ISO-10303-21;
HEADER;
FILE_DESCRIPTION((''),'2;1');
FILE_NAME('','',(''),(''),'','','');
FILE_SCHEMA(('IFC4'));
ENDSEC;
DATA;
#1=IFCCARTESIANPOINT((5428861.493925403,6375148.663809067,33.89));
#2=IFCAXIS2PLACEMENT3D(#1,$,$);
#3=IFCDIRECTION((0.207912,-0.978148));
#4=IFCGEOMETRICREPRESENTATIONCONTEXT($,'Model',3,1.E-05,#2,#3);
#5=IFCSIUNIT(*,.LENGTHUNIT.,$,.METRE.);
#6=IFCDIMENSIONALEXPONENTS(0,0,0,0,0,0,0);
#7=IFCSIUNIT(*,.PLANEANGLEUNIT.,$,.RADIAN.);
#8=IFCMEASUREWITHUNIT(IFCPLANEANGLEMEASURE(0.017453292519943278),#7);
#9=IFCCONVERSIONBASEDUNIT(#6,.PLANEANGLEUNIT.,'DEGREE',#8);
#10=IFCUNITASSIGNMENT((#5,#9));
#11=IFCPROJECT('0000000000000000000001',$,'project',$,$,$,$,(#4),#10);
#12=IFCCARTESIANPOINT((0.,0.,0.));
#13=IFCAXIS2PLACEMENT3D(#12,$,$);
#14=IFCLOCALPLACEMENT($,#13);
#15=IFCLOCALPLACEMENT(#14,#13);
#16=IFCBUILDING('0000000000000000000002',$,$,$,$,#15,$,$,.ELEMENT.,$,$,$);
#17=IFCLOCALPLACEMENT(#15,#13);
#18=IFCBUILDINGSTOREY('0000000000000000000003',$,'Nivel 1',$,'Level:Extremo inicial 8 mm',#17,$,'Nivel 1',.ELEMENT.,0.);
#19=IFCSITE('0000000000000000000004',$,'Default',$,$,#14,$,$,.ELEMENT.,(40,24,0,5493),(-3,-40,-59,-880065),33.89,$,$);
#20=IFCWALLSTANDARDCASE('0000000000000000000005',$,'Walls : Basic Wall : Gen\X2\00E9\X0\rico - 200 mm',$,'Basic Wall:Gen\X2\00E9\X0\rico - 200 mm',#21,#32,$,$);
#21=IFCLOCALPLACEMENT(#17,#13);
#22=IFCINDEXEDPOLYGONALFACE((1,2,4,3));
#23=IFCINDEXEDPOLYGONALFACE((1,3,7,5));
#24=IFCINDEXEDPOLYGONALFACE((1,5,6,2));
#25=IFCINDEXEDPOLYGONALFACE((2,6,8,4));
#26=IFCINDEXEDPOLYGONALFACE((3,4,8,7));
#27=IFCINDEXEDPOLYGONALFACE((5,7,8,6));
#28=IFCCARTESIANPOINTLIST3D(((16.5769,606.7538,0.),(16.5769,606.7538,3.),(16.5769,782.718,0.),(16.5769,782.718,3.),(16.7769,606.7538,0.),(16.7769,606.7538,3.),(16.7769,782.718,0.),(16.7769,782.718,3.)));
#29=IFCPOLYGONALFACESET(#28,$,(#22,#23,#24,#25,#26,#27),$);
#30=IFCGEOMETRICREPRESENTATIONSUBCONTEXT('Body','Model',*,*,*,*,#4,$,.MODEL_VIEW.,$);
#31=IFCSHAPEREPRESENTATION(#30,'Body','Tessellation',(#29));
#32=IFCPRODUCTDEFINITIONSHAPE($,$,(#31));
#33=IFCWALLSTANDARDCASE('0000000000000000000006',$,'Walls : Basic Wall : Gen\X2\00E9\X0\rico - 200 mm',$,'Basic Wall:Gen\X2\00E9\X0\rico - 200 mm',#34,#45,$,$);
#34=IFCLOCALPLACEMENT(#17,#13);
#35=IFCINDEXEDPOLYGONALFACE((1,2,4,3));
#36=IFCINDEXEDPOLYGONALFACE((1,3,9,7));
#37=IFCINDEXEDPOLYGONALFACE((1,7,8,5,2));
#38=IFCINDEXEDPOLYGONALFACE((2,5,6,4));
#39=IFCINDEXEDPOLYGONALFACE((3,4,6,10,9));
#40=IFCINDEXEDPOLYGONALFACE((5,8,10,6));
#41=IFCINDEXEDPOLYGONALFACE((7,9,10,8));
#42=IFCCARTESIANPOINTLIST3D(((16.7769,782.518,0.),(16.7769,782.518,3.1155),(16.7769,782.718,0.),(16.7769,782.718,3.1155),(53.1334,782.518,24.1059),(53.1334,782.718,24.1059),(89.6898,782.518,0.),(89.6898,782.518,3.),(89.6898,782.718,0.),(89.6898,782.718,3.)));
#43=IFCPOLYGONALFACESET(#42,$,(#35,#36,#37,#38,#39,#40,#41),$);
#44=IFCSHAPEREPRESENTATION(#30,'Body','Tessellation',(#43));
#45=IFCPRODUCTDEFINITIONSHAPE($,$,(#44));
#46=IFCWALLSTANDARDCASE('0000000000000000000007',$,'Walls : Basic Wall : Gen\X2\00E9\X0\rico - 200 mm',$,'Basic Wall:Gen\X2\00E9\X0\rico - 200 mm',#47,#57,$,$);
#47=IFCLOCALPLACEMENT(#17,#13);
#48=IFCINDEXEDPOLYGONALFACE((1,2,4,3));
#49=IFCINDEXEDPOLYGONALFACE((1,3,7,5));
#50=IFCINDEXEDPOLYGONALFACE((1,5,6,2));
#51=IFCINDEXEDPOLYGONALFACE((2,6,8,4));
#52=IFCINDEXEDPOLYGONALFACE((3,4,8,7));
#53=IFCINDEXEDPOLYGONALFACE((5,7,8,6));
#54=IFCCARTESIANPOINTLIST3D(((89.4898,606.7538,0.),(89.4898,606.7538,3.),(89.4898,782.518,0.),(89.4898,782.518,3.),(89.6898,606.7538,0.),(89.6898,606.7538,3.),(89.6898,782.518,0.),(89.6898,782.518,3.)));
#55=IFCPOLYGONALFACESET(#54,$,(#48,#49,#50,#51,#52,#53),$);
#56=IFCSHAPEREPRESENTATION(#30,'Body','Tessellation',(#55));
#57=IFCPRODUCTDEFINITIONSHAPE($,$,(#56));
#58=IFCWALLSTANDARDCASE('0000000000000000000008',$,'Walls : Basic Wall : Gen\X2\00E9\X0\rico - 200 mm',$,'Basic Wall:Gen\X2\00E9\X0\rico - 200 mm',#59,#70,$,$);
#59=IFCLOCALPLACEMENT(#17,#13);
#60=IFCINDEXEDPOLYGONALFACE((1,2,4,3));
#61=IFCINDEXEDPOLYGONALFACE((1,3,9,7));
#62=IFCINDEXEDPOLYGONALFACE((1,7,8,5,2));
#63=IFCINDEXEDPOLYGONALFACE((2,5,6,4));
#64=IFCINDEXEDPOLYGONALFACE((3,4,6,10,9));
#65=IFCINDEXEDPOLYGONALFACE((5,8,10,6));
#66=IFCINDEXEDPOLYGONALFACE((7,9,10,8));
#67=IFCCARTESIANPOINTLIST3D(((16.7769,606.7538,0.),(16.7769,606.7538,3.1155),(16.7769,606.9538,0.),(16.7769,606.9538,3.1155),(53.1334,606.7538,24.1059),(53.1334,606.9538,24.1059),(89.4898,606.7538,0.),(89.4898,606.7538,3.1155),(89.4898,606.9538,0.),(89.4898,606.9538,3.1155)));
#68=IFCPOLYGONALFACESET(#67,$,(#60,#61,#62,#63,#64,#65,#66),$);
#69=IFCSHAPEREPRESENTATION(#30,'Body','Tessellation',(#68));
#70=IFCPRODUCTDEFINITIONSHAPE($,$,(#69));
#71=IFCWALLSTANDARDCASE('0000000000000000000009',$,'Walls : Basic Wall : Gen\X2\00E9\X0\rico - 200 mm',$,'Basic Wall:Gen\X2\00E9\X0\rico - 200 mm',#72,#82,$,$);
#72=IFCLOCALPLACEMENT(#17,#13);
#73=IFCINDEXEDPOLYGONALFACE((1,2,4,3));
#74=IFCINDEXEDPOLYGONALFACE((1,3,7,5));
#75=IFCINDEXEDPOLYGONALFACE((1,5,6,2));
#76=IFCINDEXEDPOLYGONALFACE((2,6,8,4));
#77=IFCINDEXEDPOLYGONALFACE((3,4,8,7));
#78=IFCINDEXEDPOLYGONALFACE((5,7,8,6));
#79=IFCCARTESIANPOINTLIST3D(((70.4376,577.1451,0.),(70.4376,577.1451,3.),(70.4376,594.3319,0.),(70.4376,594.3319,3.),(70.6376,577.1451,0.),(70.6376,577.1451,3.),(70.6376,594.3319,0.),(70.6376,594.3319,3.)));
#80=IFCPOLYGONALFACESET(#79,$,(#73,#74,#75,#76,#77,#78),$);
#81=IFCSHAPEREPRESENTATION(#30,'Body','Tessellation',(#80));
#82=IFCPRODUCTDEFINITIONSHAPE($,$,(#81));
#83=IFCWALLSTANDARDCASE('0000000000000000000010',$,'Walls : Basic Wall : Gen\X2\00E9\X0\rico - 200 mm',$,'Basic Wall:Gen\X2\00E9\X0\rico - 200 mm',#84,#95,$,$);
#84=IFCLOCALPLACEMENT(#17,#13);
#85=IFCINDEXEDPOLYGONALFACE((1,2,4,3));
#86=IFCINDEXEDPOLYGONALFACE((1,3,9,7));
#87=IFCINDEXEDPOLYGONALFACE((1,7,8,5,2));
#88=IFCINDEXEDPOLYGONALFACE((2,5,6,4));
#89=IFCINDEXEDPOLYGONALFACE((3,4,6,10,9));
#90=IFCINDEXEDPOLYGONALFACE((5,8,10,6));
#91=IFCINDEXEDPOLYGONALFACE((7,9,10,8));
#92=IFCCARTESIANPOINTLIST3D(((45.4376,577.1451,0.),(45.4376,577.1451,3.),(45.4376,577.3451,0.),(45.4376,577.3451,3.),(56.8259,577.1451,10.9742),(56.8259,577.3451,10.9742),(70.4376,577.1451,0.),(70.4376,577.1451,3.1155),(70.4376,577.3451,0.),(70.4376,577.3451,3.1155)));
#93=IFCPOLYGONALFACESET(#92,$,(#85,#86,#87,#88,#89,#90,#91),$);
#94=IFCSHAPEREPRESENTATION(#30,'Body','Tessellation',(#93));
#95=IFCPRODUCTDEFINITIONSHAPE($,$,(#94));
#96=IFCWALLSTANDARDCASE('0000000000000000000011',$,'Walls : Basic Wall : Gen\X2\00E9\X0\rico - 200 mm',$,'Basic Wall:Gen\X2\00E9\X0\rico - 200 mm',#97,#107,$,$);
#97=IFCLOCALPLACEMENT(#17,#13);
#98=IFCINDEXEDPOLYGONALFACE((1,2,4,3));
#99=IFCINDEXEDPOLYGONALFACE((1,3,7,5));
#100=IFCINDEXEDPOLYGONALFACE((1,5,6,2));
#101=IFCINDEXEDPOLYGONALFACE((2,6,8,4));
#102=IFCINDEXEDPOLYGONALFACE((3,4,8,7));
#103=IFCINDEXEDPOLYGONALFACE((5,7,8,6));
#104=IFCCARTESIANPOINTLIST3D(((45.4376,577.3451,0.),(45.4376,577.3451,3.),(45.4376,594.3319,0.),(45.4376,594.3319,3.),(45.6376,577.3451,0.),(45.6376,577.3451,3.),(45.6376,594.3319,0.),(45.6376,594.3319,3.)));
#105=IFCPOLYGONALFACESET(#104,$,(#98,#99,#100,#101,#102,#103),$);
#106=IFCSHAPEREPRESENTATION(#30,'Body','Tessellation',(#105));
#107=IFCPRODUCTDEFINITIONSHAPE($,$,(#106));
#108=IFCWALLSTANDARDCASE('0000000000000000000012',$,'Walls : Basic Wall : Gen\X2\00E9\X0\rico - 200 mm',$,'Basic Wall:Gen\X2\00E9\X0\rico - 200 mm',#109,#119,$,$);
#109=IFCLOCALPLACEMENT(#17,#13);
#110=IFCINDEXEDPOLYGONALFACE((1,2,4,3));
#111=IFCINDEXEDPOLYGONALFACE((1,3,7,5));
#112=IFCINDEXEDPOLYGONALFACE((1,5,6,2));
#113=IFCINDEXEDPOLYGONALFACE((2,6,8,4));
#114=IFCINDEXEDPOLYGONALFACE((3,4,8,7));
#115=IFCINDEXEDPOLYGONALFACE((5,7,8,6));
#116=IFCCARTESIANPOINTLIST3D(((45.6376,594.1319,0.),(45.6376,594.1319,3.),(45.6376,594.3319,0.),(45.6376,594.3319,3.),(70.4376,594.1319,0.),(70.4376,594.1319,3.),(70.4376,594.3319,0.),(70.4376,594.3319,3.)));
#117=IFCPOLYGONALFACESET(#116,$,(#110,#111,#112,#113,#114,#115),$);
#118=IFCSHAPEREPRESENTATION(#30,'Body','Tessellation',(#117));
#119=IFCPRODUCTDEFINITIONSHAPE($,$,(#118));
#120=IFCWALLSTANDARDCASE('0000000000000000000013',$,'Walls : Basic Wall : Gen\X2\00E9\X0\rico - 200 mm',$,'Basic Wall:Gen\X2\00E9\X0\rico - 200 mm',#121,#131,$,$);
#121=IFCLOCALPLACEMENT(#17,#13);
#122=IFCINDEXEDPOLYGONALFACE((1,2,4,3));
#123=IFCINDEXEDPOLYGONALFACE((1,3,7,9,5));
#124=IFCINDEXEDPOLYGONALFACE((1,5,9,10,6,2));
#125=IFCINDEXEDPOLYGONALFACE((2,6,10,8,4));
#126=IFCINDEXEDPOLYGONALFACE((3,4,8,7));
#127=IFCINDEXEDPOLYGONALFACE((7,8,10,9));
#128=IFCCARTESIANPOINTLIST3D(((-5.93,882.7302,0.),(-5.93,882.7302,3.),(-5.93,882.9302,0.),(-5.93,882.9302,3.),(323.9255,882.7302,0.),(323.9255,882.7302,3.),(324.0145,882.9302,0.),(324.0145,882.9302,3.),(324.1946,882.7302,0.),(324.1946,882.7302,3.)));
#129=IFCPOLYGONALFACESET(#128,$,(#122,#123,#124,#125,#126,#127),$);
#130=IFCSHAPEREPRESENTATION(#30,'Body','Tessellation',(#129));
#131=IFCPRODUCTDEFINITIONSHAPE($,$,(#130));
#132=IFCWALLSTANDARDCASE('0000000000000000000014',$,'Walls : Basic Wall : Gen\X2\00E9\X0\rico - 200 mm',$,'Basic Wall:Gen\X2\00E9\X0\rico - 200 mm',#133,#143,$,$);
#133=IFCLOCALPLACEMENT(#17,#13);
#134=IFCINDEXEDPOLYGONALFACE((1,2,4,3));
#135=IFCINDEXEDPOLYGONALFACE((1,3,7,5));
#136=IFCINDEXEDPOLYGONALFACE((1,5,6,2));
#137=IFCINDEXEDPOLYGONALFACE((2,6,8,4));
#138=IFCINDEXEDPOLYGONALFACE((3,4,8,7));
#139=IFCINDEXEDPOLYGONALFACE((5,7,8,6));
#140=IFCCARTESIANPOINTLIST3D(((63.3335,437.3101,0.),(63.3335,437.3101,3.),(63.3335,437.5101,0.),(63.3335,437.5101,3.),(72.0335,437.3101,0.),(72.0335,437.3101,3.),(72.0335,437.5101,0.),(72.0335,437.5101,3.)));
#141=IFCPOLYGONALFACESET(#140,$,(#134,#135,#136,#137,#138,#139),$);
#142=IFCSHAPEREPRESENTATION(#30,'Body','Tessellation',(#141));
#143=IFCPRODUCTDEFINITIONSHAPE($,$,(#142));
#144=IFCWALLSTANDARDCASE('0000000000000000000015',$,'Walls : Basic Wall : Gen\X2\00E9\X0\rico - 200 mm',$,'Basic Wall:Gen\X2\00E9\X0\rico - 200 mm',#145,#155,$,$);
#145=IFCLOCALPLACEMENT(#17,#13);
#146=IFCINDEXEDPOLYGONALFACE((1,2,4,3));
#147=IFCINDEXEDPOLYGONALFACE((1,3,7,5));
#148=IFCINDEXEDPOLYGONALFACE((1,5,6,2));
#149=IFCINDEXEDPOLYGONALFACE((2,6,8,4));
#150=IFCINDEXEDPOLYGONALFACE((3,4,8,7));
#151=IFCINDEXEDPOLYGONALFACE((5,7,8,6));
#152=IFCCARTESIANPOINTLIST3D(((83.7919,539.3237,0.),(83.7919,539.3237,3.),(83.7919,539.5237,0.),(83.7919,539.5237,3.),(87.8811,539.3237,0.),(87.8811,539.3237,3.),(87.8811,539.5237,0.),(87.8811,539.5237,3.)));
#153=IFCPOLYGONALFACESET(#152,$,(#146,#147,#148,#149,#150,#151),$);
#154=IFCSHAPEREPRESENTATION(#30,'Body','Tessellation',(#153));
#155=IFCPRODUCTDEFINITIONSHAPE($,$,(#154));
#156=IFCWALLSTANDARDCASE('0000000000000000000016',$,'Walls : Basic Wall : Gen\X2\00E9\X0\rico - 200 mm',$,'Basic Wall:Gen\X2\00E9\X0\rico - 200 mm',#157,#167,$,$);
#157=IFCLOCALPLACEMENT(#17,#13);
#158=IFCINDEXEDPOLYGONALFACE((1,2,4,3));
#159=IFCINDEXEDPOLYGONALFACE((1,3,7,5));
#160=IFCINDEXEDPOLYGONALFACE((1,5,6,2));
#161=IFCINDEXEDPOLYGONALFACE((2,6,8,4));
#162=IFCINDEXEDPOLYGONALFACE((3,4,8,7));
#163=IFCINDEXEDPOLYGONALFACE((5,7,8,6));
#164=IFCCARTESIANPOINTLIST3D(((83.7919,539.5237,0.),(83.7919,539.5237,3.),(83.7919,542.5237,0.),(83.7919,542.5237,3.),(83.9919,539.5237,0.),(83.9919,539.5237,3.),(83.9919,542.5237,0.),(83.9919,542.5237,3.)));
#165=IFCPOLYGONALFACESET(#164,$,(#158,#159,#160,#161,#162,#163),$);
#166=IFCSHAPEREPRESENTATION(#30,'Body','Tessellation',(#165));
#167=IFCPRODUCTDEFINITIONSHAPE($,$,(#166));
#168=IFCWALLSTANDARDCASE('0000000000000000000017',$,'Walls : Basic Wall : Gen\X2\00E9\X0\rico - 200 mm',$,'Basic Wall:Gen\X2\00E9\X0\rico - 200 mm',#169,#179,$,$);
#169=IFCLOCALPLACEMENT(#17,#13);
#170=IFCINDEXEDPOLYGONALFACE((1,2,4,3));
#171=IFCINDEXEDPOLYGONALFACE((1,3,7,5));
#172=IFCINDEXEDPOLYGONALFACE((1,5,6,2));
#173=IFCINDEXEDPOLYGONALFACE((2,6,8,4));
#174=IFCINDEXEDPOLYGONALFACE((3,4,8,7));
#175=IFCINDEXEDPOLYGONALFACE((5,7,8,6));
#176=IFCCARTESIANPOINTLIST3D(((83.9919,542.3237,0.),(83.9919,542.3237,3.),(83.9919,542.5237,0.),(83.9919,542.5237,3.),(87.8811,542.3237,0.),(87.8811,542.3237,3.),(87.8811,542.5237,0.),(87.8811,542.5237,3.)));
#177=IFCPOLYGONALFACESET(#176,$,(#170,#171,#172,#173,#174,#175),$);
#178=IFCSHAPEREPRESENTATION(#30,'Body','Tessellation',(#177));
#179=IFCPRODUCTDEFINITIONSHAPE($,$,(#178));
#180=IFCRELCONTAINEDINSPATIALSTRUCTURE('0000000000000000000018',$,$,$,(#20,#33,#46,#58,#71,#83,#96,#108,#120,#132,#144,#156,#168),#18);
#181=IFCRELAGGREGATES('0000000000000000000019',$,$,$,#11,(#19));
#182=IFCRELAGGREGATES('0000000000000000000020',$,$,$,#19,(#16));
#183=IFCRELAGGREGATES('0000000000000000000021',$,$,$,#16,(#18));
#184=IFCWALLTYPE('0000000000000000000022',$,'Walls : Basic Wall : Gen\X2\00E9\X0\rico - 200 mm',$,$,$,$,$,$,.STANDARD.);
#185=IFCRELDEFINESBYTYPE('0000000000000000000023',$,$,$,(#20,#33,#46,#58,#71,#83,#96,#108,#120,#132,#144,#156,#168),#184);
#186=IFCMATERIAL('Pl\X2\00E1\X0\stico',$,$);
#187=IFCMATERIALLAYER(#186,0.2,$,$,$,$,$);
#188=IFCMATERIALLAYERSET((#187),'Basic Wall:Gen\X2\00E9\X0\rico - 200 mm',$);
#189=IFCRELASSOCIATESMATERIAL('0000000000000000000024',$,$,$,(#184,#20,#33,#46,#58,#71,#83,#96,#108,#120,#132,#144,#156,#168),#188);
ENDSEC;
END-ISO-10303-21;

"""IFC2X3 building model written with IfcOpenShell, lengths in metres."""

from ifc_helpers import new_model, entity, si_unit, converted_unit, direction, frame, frame_2d, origin, place, context, subcontext, project, spatial, polyline, rectangle, outline, extrude, clip, bounded_halfspace, material, layer, layer_set, layer_usage, type_object, element, save


model = new_model("IFC2X3")

# Units and contexts
model_context = context("Model", 3, precision=1e-05, world=frame((5428861.493925403, 6375148.663809067, 33.89)), true_north=direction((0.207912, -0.978148)))
body_context = subcontext(model_context, "Body", "Model", "MODEL_VIEW")
ifc_project = project(units=[si_unit("LENGTHUNIT", "METRE"), converted_unit("PLANEANGLEUNIT", "DEGREE", entity("IfcPlaneAngleMeasure", 0.017453292519943278), si_unit("PLANEANGLEUNIT", "RADIAN"), dimensions=[0, 0, 0, 0, 0, 0, 0])], contexts=[model_context])

# Site, building, storey
site_placement = place(None, origin())
site = spatial("IfcSite", under=ifc_project, at=site_placement, Name="Default", CompositionType="ELEMENT", RefLatitude=(40, 24, 0, 5493), RefLongitude=(-3, -40, -59, -880065), RefElevation=33.89)
building_placement = place(site_placement, origin())
building = spatial("IfcBuilding", under=site, at=building_placement, CompositionType="ELEMENT")
storey_placement = place(building_placement, origin())
storey = spatial("IfcBuildingStorey", under=building, at=storey_placement, Name="Nivel 1", ObjectType="Level:Extremo inicial 8 mm", LongName="Nivel 1", CompositionType="ELEMENT", Elevation=0.0)

# Walls
ifc_material_1 = material(Name="Plástico")
ifc_layer_1 = layer(ifc_material_1, 0.2)
ifc_layer_set_1 = layer_set([ifc_layer_1], Name="Basic Wall:Genérico - 200 mm")
ifc_layer_usage_1 = layer_usage(ifc_layer_set_1, "AXIS2", "NEGATIVE", 0.1)
wall_type = type_object("IfcWallType", Name="Walls : Basic Wall : Genérico - 200 mm", PredefinedType="STANDARD", material=ifc_layer_set_1)
wall_1_placement = place(storey_placement, frame((16.6769, 606.7538, 0.0), z_axis=(0.0, 0.0, 1.0), x_axis=(0.0, 1.0, 0.0)))
element("IfcWallStandardCase", 1, at=wall_1_placement, inside=storey, type_object=wall_type, material=ifc_layer_usage_1, Name="Walls : Basic Wall : Genérico - 200 mm", ObjectType="Basic Wall:Genérico - 200 mm", context=body_context, shape_type="SweptSolid", body=[
    extrude(rectangle(XDim=175.9642, YDim=0.2, at=frame_2d((87.9821, 0.0), x_axis=(-1.0, 0.0))), origin(), (0.0, 0.0, 1.0), 3.0),
])
ifc_layer_usage_2 = layer_usage(ifc_layer_set_1, "AXIS2", "NEGATIVE", 0.1)
wall_2_placement = place(storey_placement, frame((16.7769, 782.618, 0.0)))
element("IfcWallStandardCase", 2, at=wall_2_placement, inside=storey, type_object=wall_type, material=ifc_layer_usage_2, Name="Walls : Basic Wall : Genérico - 200 mm", ObjectType="Basic Wall:Genérico - 200 mm", context=body_context, shape_type="Clipping", body=[
    clip(clip(extrude(rectangle(XDim=72.9129, YDim=0.2, at=frame_2d((36.4564, 0.0), x_axis=(-1.0, 0.0))), origin(), (0.0, 0.0, 1.0), 24.1059), bounded_halfspace(frame((36.3564, -0.1, 24.1059), z_axis=(0.5, 0.0, 0.866025), x_axis=(0.0, 1.0, 0.0)), False, frame((36.3564, -0.1, 24.1059)), polyline([(0.0, 0.0), (36.5564, 0.0), (36.5564, 0.2), (0.0, 0.2), (0.0, 0.0)]))), bounded_halfspace(frame((0.0, -0.1, 3.1155), z_axis=(-0.5, 0.0, 0.866025), x_axis=(0.0, -1.0, 0.0)), False, frame((0.0, -0.1, 3.1155)), polyline([(0.0, 0.0), (36.3564, 0.0), (36.3564, 0.2), (0.0, 0.2), (0.0, 0.0)]))),
])
ifc_layer_usage_3 = layer_usage(ifc_layer_set_1, "AXIS2", "NEGATIVE", 0.1)
wall_3_placement = place(storey_placement, frame((89.5898, 782.518, 0.0), z_axis=(0.0, 0.0, 1.0), x_axis=(0.0, -1.0, 0.0)))
element("IfcWallStandardCase", 3, at=wall_3_placement, inside=storey, type_object=wall_type, material=ifc_layer_usage_3, Name="Walls : Basic Wall : Genérico - 200 mm", ObjectType="Basic Wall:Genérico - 200 mm", context=body_context, shape_type="SweptSolid", body=[
    extrude(rectangle(XDim=175.7642, YDim=0.2, at=frame_2d((87.8821, 0.0), x_axis=(-1.0, 0.0))), origin(), (0.0, 0.0, 1.0), 3.0),
])
ifc_layer_usage_4 = layer_usage(ifc_layer_set_1, "AXIS2", "NEGATIVE", 0.1)
wall_4_placement = place(storey_placement, frame((89.4898, 606.8538, 0.0), z_axis=(0.0, 0.0, 1.0), x_axis=(-1.0, 0.0, 0.0)))
element("IfcWallStandardCase", 4, at=wall_4_placement, inside=storey, type_object=wall_type, material=ifc_layer_usage_4, Name="Walls : Basic Wall : Genérico - 200 mm", ObjectType="Basic Wall:Genérico - 200 mm", context=body_context, shape_type="Clipping", body=[
    clip(clip(extrude(rectangle(XDim=72.7129, YDim=0.2, at=frame_2d((36.3564, 0.0), x_axis=(-1.0, 0.0))), origin(), (0.0, 0.0, 1.0), 24.1059), bounded_halfspace(frame((0.0, -0.1, 3.1155), z_axis=(-0.5, 0.0, 0.866025), x_axis=(0.0, -1.0, 0.0)), False, frame((0.0, -0.1, 3.1155)), polyline([(0.0, 0.0), (36.3564, 0.0), (36.3564, 0.2), (0.0, 0.2), (0.0, 0.0)]))), bounded_halfspace(frame((36.3564, -0.1, 24.1059), z_axis=(0.5, 0.0, 0.866025), x_axis=(0.0, 1.0, 0.0)), False, frame((36.3564, -0.1, 24.1059)), polyline([(0.0, 0.0), (36.3564, 0.0), (36.3564, 0.2), (0.0, 0.2), (0.0, 0.0)]))),
])
ifc_layer_usage_5 = layer_usage(ifc_layer_set_1, "AXIS2", "NEGATIVE", 0.1)
wall_5_placement = place(storey_placement, frame((70.5376, 594.3319, 0.0), z_axis=(0.0, 0.0, 1.0), x_axis=(0.0, -1.0, 0.0)))
element("IfcWallStandardCase", 5, at=wall_5_placement, inside=storey, type_object=wall_type, material=ifc_layer_usage_5, Name="Walls : Basic Wall : Genérico - 200 mm", ObjectType="Basic Wall:Genérico - 200 mm", context=body_context, shape_type="SweptSolid", body=[
    extrude(rectangle(XDim=17.1868, YDim=0.2, at=frame_2d((8.5934, 0.0), x_axis=(-1.0, 0.0))), origin(), (0.0, 0.0, 1.0), 3.0),
])
ifc_layer_usage_6 = layer_usage(ifc_layer_set_1, "AXIS2", "NEGATIVE", 0.1)
wall_6_placement = place(storey_placement, frame((70.4376, 577.2451, 0.0), z_axis=(0.0, 0.0, 1.0), x_axis=(-1.0, 0.0, 0.0)))
element("IfcWallStandardCase", 6, at=wall_6_placement, inside=storey, type_object=wall_type, material=ifc_layer_usage_6, Name="Walls : Basic Wall : Genérico - 200 mm", ObjectType="Basic Wall:Genérico - 200 mm", context=body_context, shape_type="Clipping", body=[
    clip(clip(extrude(rectangle(XDim=25.0, YDim=0.2, at=frame_2d((12.5, 0.0), x_axis=(-1.0, 0.0))), origin(), (0.0, 0.0, 1.0), 10.9742), bounded_halfspace(frame((0.0, -0.1, 3.1155), z_axis=(-0.5, 0.0, 0.866025), x_axis=(0.0, -1.0, 0.0)), False, frame((0.0, -0.1, 3.1155)), polyline([(0.0, 0.0), (13.6117, 0.0), (13.6117, 0.2), (0.0, 0.2), (0.0, 0.0)]))), bounded_halfspace(frame((13.6117, -0.1, 10.9742), z_axis=(0.573576, 0.0, 0.819152), x_axis=(0.0, 1.0, 0.0)), False, frame((13.6117, -0.1, 10.9742)), polyline([(0.0, 0.0), (11.3883, 0.0), (11.3883, 0.2), (0.0, 0.2), (0.0, 0.0)]))),
])
ifc_layer_usage_7 = layer_usage(ifc_layer_set_1, "AXIS2", "NEGATIVE", 0.1)
wall_7_placement = place(storey_placement, frame((45.5376, 577.3451, 0.0), z_axis=(0.0, 0.0, 1.0), x_axis=(0.0, 1.0, 0.0)))
element("IfcWallStandardCase", 7, at=wall_7_placement, inside=storey, type_object=wall_type, material=ifc_layer_usage_7, Name="Walls : Basic Wall : Genérico - 200 mm", ObjectType="Basic Wall:Genérico - 200 mm", context=body_context, shape_type="SweptSolid", body=[
    extrude(rectangle(XDim=16.9868, YDim=0.2, at=frame_2d((8.4934, 0.0), x_axis=(-1.0, 0.0))), origin(), (0.0, 0.0, 1.0), 3.0),
])
ifc_layer_usage_8 = layer_usage(ifc_layer_set_1, "AXIS2", "NEGATIVE", 0.1)
wall_8_placement = place(storey_placement, frame((70.4376, 594.2319, 0.0), z_axis=(0.0, 0.0, 1.0), x_axis=(-1.0, 0.0, 0.0)))
element("IfcWallStandardCase", 8, at=wall_8_placement, inside=storey, type_object=wall_type, material=ifc_layer_usage_8, Name="Walls : Basic Wall : Genérico - 200 mm", ObjectType="Basic Wall:Genérico - 200 mm", context=body_context, shape_type="SweptSolid", body=[
    extrude(rectangle(XDim=24.8, YDim=0.2, at=frame_2d((12.4, 0.0), x_axis=(-1.0, 0.0))), origin(), (0.0, 0.0, 1.0), 3.0),
])
ifc_layer_usage_9 = layer_usage(ifc_layer_set_1, "AXIS2", "NEGATIVE", 0.1)
wall_9_placement = place(storey_placement, frame((-5.93, 882.8302, 0.0)))
element("IfcWallStandardCase", 9, at=wall_9_placement, inside=storey, type_object=wall_type, material=ifc_layer_usage_9, Name="Walls : Basic Wall : Genérico - 200 mm", ObjectType="Basic Wall:Genérico - 200 mm", context=body_context, shape_type="SweptSolid", body=[
    extrude(outline(polyline([(330.1246, -0.1), (329.9445, 0.1), (0.0, 0.1), (0.0, -0.1), (329.8555, -0.1), (330.1246, -0.1)])), origin(), (0.0, 0.0, 1.0), 3.0),
])
ifc_layer_usage_10 = layer_usage(ifc_layer_set_1, "AXIS2", "NEGATIVE", 0.1)
wall_10_placement = place(storey_placement, frame((63.3335, 437.4101, 0.0)))
element("IfcWallStandardCase", 10, at=wall_10_placement, inside=storey, type_object=wall_type, material=ifc_layer_usage_10, Name="Walls : Basic Wall : Genérico - 200 mm", ObjectType="Basic Wall:Genérico - 200 mm", context=body_context, shape_type="SweptSolid", body=[
    extrude(rectangle(XDim=8.7, YDim=0.2, at=frame_2d((4.35, 0.0), x_axis=(-1.0, 0.0))), origin(), (0.0, 0.0, 1.0), 3.0),
])
ifc_layer_usage_11 = layer_usage(ifc_layer_set_1, "AXIS2", "NEGATIVE", 0.1)
wall_11_placement = place(storey_placement, frame((87.8811, 539.4237, 0.0), z_axis=(0.0, 0.0, 1.0), x_axis=(-1.0, 0.0, 0.0)))
element("IfcWallStandardCase", 11, at=wall_11_placement, inside=storey, type_object=wall_type, material=ifc_layer_usage_11, Name="Walls : Basic Wall : Genérico - 200 mm", ObjectType="Basic Wall:Genérico - 200 mm", context=body_context, shape_type="SweptSolid", body=[
    extrude(rectangle(XDim=4.0892, YDim=0.2, at=frame_2d((2.0446, 0.0), x_axis=(-1.0, 0.0))), origin(), (0.0, 0.0, 1.0), 3.0),
])
ifc_layer_usage_12 = layer_usage(ifc_layer_set_1, "AXIS2", "POSITIVE", -0.1)
wall_12_placement = place(storey_placement, frame((83.8919, 539.5237, 0.0), z_axis=(0.0, 0.0, 1.0), x_axis=(0.0, 1.0, 0.0)))
element("IfcWallStandardCase", 12, at=wall_12_placement, inside=storey, type_object=wall_type, material=ifc_layer_usage_12, Name="Walls : Basic Wall : Genérico - 200 mm", ObjectType="Basic Wall:Genérico - 200 mm", context=body_context, shape_type="SweptSolid", body=[
    extrude(rectangle(XDim=3.0, YDim=0.2, at=frame_2d((1.5, 0.0), x_axis=(-1.0, 0.0))), origin(), (0.0, 0.0, 1.0), 3.0),
])
ifc_layer_usage_13 = layer_usage(ifc_layer_set_1, "AXIS2", "NEGATIVE", 0.1)
wall_13_placement = place(storey_placement, frame((83.9919, 542.4237, 0.0)))
element("IfcWallStandardCase", 13, at=wall_13_placement, inside=storey, type_object=wall_type, material=ifc_layer_usage_13, Name="Walls : Basic Wall : Genérico - 200 mm", ObjectType="Basic Wall:Genérico - 200 mm", context=body_context, shape_type="SweptSolid", body=[
    extrude(rectangle(XDim=3.8892, YDim=0.2, at=frame_2d((1.9446, 0.0), x_axis=(-1.0, 0.0))), origin(), (0.0, 0.0, 1.0), 3.0),
])

save(model, "model.ifc")
